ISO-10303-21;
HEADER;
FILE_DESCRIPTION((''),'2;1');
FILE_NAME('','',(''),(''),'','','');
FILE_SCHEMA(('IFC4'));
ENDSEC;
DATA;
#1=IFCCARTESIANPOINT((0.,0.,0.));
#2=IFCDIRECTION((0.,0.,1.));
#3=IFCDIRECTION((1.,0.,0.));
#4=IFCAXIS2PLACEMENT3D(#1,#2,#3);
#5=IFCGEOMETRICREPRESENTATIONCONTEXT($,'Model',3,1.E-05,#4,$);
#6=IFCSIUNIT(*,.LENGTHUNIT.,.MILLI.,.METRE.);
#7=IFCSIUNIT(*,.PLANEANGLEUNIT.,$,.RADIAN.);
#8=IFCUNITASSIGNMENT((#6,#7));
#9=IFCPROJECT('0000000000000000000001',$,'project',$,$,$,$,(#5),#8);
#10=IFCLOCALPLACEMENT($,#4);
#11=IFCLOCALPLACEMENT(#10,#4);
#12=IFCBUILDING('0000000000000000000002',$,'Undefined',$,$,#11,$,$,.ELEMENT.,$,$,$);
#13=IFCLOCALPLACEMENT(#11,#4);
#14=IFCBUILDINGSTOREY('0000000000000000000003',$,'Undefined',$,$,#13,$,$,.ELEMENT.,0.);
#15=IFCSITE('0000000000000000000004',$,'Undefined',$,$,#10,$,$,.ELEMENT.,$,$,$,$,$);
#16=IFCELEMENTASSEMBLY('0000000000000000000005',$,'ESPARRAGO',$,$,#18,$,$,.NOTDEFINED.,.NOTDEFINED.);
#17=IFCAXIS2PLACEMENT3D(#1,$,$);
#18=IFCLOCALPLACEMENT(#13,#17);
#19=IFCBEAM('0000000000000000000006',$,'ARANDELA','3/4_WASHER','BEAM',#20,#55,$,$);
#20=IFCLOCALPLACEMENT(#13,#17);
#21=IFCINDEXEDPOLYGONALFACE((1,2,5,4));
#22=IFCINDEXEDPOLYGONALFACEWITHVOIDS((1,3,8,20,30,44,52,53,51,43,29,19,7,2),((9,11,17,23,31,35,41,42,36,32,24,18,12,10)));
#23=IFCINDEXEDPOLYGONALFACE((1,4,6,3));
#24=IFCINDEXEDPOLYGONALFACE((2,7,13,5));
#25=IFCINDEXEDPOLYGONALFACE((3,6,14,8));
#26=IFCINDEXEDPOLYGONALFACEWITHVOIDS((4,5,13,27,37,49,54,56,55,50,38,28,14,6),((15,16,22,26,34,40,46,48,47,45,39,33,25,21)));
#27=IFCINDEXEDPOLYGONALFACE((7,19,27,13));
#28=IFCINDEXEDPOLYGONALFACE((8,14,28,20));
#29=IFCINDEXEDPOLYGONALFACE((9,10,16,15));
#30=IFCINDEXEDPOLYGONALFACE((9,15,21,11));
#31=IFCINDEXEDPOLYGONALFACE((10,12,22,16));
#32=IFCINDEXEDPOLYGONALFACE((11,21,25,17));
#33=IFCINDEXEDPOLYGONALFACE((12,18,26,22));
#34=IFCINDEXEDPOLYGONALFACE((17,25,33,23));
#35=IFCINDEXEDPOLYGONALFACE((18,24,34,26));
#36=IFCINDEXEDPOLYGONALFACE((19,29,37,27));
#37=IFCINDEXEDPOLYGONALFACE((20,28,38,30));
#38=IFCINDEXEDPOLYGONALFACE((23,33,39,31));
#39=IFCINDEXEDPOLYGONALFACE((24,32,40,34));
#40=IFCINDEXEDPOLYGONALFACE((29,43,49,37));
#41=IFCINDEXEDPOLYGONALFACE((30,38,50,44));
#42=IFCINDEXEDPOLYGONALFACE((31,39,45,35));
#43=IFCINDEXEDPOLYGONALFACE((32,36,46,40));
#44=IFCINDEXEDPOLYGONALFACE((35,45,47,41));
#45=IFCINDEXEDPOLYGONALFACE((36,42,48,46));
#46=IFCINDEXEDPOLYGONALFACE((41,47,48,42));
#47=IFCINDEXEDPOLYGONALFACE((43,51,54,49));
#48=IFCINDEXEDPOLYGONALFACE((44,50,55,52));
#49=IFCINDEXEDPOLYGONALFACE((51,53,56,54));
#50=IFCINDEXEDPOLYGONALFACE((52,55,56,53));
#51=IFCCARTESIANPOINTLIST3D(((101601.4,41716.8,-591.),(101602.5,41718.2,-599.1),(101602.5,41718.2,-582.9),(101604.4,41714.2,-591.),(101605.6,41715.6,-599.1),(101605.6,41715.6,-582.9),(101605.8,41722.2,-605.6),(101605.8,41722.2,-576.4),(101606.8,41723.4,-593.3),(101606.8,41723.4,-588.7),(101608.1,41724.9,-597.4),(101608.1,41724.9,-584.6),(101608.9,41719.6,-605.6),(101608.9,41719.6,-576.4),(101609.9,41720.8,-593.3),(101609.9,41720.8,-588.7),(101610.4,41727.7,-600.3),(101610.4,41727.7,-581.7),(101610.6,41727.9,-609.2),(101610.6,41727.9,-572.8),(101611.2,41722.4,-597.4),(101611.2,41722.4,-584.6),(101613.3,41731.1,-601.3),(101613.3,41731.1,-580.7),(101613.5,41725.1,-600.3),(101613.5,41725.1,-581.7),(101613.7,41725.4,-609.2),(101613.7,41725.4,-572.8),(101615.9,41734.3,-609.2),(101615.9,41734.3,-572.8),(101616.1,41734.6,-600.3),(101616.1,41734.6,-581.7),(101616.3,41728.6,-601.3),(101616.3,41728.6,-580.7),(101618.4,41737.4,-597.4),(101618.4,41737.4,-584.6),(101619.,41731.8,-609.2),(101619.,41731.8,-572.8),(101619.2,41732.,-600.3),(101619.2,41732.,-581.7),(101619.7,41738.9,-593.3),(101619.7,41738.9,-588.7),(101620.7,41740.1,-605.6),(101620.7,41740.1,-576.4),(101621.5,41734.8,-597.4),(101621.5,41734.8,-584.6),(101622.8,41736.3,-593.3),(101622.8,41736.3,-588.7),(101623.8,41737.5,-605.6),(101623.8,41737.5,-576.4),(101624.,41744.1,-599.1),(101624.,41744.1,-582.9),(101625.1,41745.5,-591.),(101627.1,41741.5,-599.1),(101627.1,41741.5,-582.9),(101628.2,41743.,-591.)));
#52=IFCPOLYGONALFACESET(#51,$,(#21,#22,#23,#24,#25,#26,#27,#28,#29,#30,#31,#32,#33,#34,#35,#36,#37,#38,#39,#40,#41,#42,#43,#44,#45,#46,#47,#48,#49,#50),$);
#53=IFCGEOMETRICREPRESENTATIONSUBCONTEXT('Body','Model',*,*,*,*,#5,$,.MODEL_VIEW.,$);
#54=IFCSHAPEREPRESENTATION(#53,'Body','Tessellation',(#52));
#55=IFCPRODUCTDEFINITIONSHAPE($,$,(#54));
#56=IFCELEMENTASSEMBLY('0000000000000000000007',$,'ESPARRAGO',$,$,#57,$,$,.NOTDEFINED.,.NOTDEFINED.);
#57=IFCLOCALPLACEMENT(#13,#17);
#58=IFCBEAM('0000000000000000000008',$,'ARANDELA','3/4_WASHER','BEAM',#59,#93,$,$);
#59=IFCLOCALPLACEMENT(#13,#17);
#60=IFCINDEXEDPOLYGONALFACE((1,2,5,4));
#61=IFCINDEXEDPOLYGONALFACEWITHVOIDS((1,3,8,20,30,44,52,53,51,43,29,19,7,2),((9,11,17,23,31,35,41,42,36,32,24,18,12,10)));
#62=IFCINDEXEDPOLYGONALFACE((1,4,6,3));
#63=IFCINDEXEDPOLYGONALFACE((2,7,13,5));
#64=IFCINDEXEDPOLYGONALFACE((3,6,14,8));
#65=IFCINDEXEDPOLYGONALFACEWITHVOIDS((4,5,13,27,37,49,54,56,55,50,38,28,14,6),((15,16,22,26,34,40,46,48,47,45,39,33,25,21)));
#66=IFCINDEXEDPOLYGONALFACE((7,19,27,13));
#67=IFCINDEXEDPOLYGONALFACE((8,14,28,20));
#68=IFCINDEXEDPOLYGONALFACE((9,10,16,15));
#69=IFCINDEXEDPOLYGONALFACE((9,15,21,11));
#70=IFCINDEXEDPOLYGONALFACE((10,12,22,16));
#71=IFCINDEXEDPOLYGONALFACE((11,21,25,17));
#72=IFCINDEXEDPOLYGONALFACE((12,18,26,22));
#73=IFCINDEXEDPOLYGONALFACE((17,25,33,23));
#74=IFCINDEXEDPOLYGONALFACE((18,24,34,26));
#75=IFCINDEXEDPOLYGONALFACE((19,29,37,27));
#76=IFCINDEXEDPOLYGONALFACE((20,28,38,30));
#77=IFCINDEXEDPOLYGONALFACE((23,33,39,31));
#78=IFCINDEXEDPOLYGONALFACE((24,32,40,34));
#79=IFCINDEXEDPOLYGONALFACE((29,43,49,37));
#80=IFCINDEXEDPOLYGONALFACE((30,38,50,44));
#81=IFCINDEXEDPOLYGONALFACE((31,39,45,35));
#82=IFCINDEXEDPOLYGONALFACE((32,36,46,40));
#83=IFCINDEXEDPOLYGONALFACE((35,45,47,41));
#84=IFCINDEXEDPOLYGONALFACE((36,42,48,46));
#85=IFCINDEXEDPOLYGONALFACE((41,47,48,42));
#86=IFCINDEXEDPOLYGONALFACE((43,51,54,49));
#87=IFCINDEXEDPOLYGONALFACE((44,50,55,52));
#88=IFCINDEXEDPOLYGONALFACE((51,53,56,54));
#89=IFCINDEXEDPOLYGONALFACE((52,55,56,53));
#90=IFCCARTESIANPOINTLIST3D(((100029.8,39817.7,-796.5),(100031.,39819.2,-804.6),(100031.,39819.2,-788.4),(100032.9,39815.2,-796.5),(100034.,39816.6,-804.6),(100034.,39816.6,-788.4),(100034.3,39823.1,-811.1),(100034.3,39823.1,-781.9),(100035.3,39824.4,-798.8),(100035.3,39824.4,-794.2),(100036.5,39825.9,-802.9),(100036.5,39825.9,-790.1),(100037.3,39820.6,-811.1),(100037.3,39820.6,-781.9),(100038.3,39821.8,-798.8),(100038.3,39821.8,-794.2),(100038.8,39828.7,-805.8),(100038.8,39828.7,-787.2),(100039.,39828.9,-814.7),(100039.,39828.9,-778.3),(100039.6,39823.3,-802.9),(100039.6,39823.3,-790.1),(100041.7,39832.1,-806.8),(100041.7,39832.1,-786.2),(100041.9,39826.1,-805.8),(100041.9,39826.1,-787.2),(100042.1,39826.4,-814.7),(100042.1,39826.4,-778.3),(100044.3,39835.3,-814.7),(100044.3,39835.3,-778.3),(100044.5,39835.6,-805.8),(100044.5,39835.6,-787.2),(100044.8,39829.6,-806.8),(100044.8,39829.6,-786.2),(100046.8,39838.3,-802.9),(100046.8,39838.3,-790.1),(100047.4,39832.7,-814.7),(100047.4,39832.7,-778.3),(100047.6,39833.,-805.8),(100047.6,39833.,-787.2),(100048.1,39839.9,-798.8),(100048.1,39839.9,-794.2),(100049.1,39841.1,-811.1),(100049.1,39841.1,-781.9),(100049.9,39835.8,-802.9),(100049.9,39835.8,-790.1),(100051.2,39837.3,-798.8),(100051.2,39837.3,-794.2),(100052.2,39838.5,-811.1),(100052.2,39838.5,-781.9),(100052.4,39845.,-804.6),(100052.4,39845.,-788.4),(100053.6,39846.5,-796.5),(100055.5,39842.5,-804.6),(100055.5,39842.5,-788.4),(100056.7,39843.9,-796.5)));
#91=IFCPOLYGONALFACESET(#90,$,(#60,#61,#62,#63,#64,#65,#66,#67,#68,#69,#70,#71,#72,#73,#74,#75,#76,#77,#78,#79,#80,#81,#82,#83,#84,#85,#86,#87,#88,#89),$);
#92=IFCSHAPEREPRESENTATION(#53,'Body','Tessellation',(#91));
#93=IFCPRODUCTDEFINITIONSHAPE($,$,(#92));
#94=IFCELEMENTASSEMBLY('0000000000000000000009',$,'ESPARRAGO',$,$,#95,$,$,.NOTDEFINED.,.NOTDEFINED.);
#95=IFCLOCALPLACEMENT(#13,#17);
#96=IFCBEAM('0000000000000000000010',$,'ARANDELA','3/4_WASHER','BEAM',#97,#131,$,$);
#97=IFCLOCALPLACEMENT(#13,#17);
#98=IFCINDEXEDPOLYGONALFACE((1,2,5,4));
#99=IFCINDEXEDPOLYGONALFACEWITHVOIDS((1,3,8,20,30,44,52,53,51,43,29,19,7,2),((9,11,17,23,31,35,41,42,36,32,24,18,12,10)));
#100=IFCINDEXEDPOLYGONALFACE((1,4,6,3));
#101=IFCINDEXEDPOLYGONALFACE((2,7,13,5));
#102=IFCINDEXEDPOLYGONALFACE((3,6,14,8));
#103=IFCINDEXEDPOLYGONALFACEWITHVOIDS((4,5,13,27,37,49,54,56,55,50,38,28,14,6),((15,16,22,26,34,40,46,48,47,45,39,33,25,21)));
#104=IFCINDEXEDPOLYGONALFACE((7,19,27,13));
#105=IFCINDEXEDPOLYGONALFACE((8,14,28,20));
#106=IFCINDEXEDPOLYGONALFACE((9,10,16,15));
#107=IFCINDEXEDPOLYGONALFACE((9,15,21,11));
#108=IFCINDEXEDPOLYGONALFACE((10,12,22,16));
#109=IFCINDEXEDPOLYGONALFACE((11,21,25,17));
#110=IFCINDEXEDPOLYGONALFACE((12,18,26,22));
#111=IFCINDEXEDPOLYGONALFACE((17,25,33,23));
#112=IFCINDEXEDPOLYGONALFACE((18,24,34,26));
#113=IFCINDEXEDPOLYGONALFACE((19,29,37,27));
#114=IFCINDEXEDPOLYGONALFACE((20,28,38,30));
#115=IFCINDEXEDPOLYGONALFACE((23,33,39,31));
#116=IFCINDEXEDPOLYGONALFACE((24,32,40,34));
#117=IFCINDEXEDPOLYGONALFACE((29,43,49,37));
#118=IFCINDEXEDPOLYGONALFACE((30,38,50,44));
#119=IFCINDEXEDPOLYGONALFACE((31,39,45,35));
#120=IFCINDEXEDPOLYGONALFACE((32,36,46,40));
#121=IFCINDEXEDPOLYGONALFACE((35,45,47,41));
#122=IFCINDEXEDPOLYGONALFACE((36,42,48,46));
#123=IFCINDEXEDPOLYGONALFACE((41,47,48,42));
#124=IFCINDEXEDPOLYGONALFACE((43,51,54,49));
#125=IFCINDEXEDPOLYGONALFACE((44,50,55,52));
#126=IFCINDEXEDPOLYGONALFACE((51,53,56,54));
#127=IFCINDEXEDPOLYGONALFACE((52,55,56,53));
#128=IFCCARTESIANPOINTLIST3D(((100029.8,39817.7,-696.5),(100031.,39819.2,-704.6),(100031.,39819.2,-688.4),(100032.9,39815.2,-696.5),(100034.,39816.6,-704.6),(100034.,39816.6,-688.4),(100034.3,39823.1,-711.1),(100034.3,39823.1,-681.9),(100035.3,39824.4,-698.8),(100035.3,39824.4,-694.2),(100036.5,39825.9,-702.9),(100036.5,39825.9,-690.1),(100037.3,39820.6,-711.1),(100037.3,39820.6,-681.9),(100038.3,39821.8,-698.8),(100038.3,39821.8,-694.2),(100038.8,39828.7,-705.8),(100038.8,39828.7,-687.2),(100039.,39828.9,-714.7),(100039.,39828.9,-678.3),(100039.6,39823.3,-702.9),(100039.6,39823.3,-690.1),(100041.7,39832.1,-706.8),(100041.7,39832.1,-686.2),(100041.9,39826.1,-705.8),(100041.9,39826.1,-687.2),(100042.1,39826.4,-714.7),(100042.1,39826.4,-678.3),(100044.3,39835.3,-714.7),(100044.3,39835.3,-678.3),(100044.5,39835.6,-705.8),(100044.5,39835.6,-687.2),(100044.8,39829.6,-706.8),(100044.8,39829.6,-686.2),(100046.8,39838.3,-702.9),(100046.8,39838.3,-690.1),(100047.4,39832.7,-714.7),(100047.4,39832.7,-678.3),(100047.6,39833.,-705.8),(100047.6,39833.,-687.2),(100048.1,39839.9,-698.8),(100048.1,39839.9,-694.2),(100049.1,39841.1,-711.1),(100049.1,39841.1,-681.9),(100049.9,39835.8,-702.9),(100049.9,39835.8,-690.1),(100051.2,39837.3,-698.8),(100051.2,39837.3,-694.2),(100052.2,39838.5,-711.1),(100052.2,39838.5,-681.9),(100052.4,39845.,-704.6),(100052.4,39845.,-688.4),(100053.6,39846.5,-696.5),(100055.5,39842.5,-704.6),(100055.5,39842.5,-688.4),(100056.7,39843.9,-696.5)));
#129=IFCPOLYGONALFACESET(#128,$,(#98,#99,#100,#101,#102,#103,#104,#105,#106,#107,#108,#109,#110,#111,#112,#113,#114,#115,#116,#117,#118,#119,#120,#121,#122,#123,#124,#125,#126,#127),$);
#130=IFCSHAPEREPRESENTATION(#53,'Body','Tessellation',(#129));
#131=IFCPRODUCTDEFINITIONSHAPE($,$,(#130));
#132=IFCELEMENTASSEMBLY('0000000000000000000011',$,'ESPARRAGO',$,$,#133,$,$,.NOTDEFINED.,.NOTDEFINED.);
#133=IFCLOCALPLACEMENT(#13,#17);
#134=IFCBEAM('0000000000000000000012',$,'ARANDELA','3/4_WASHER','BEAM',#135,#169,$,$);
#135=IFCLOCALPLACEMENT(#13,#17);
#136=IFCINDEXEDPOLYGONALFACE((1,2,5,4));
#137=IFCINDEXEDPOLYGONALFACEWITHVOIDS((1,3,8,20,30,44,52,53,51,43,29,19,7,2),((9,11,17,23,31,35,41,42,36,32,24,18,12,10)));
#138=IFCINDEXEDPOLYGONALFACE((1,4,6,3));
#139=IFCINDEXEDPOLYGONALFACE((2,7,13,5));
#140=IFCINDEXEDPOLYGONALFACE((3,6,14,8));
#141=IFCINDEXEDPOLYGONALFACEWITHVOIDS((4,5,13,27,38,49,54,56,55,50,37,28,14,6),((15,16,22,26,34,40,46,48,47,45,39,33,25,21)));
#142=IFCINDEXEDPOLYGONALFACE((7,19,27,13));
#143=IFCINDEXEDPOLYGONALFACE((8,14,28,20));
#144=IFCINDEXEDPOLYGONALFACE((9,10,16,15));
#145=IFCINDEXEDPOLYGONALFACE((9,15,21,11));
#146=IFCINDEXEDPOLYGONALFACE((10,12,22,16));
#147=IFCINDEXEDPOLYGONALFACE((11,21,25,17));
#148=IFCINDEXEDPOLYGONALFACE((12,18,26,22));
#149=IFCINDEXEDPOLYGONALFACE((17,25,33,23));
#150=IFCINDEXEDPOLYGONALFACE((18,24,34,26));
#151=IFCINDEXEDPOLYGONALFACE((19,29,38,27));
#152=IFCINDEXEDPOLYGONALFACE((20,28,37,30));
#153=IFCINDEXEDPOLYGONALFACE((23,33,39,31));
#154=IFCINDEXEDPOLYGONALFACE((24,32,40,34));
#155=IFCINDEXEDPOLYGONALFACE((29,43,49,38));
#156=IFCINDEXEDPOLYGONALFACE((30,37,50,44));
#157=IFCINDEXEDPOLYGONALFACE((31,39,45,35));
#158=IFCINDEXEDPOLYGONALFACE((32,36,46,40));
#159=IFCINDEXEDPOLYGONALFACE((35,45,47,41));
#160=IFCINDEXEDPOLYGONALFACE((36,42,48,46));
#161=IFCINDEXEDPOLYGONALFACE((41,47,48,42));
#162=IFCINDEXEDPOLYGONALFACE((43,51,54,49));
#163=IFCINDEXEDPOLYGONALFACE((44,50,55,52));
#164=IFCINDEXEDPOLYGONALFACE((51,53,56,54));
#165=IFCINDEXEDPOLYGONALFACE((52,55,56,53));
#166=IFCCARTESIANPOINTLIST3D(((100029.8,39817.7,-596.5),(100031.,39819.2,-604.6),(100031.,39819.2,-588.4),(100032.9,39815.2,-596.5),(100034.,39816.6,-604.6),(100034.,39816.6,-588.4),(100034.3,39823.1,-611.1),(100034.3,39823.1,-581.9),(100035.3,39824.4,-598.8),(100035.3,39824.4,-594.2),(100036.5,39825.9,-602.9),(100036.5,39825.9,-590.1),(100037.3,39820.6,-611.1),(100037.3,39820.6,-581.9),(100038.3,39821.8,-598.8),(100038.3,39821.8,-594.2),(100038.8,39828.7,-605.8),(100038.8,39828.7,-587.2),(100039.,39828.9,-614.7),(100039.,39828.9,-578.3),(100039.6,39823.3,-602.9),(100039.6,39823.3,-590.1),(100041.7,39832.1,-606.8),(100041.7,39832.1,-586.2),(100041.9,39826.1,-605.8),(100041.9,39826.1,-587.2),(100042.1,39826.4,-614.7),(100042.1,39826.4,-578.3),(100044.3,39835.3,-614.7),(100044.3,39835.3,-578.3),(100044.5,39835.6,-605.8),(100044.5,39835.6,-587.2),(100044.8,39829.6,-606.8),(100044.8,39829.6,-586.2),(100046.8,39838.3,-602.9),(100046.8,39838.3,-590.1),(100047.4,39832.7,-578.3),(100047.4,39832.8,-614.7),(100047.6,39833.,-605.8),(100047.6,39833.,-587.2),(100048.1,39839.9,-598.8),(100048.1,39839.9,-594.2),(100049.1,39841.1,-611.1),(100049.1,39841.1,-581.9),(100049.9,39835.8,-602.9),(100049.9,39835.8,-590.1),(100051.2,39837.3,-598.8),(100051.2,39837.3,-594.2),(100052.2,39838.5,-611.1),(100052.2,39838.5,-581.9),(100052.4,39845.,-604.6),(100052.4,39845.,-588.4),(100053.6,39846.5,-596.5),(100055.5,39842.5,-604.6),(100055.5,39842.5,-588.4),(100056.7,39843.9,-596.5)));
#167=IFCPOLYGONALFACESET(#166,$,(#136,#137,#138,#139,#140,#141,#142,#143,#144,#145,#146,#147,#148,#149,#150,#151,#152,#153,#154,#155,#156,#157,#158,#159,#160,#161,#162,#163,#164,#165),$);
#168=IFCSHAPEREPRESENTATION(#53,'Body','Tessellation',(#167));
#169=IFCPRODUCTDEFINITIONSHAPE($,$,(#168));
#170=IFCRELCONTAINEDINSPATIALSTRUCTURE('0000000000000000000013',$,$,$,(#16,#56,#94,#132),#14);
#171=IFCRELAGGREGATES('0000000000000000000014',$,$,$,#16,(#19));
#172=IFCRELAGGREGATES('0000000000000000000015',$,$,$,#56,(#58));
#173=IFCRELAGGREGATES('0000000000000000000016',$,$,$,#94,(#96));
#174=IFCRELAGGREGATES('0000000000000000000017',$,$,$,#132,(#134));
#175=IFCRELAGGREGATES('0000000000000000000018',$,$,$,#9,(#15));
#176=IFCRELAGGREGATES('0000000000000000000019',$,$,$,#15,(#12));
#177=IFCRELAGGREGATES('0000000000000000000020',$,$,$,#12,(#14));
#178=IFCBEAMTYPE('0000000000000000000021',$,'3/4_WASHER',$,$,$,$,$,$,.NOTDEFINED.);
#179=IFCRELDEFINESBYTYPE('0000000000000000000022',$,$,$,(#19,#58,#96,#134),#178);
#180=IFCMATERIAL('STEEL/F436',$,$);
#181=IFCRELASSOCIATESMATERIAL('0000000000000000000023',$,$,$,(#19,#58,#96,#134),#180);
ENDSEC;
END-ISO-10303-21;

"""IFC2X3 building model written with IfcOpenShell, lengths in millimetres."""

from ifc_helpers import new_model, si_unit, frame, origin_with_axes, place, context, subcontext, project, spatial, polyline, outline, extrude, material, type_object, element, aggregate, save


model = new_model("IFC2X3")

# Units and contexts
model_context = context("Model", 3, precision=1e-05, world=origin_with_axes())
body_context = subcontext(model_context, "Body", "Model", "MODEL_VIEW")
ifc_project = project(units=[si_unit("LENGTHUNIT", "METRE", prefix="MILLI"), si_unit("PLANEANGLEUNIT", "RADIAN")], contexts=[model_context])

# Site, building, storey
site_placement = place(None, origin_with_axes())
site = spatial("IfcSite", under=ifc_project, at=site_placement, Name="Undefined", CompositionType="ELEMENT")
building_placement = place(site_placement, origin_with_axes())
building = spatial("IfcBuilding", under=site, at=building_placement, Name="Undefined", CompositionType="ELEMENT")
storey_placement = place(building_placement, origin_with_axes())
storey = spatial("IfcBuildingStorey", under=building, at=storey_placement, Name="Undefined", CompositionType="ELEMENT", Elevation=0.0)

# Element assemblies, beams
ifc_material_1 = material(Name="STEEL/F436")
beam_type_1 = type_object("IfcBeamType", Name="3/4_WASHER", PredefinedType="NOTDEFINED")
assembly_1_placement = place(storey_placement, origin_with_axes())
assembly_1 = element("IfcElementAssembly", 1, at=assembly_1_placement, inside=storey, Name="ESPARRAGO", AssemblyPlace="NOTDEFINED", PredefinedType="NOTDEFINED")
beam_1_placement = place(assembly_1_placement, frame((101613.3, 41731.1, -591.0), z_axis=(0.000066, -0.000055, 1.0), x_axis=(0.7704, -0.637561, -0.000086)))
beam_1 = element("IfcBeam", 2, at=beam_1_placement, type_object=beam_type_1, material=ifc_material_1, Name="ARANDELA", Description="3/4_WASHER", ObjectType="BEAM", context=body_context, shape_type="SweptSolid", body=[
    extrude(outline(polyline([(-11.6, -14.6), (-16.8, -8.1), (-18.6, 0.0), (-16.8, 8.1), (-11.6, 14.6), (-4.2, 18.2), (4.2, 18.2), (11.6, 14.6), (16.8, 8.1), (18.6, 0.0), (16.8, -8.1), (11.6, -14.6), (4.2, -18.2), (-4.2, -18.2), (-11.6, -14.6)]), holes=[polyline([(-4.5, 9.3), (-8.1, 6.4), (-10.1, 2.3), (-10.1, -2.3), (-8.1, -6.4), (-4.5, -9.3), (0.0, -10.3), (4.5, -9.3), (8.1, -6.4), (10.1, -2.3), (10.1, 2.3), (8.1, 6.4), (4.5, 9.3), (0.0, 10.3), (-4.5, 9.3)])]), frame((4.0, 0.0, 0.0), z_axis=(-1.0, 0.0, 0.0), x_axis=(0.0, -1.0, 0.0)), (0.0, 0.0, 1.0), 4.0),
])
assembly_2_placement = place(storey_placement, origin_with_axes())
assembly_2 = element("IfcElementAssembly", 3, at=assembly_2_placement, inside=storey, Name="ESPARRAGO", AssemblyPlace="NOTDEFINED", PredefinedType="NOTDEFINED")
beam_2_placement = place(assembly_2_placement, frame((100041.7, 39832.1, -796.5), z_axis=(0.000066, -0.000055, 1.0), x_axis=(0.7704, -0.637561, -0.000086)))
beam_2 = element("IfcBeam", 4, at=beam_2_placement, type_object=beam_type_1, material=ifc_material_1, Name="ARANDELA", Description="3/4_WASHER", ObjectType="BEAM", context=body_context, shape_type="SweptSolid", body=[
    extrude(outline(polyline([(-11.6, -14.6), (-16.8, -8.1), (-18.6, 0.0), (-16.8, 8.1), (-11.6, 14.6), (-4.2, 18.2), (4.2, 18.2), (11.6, 14.6), (16.8, 8.1), (18.6, 0.0), (16.8, -8.1), (11.6, -14.6), (4.2, -18.2), (-4.2, -18.2), (-11.6, -14.6)]), holes=[polyline([(-4.5, 9.3), (-8.1, 6.4), (-10.1, 2.3), (-10.1, -2.3), (-8.1, -6.4), (-4.5, -9.3), (0.0, -10.3), (4.5, -9.3), (8.1, -6.4), (10.1, -2.3), (10.1, 2.3), (8.1, 6.4), (4.5, 9.3), (0.0, 10.3), (-4.5, 9.3)])]), frame((4.0, 0.0, 0.0), z_axis=(-1.0, 0.0, 0.0), x_axis=(0.0, -1.0, 0.0)), (0.0, 0.0, 1.0), 4.0),
])
assembly_3_placement = place(storey_placement, origin_with_axes())
assembly_3 = element("IfcElementAssembly", 5, at=assembly_3_placement, inside=storey, Name="ESPARRAGO", AssemblyPlace="NOTDEFINED", PredefinedType="NOTDEFINED")
beam_3_placement = place(assembly_3_placement, frame((100041.7, 39832.1, -696.5), z_axis=(0.000066, -0.000055, 1.0), x_axis=(0.7704, -0.637561, -0.000086)))
beam_3 = element("IfcBeam", 6, at=beam_3_placement, type_object=beam_type_1, material=ifc_material_1, Name="ARANDELA", Description="3/4_WASHER", ObjectType="BEAM", context=body_context, shape_type="SweptSolid", body=[
    extrude(outline(polyline([(-11.6, -14.6), (-16.8, -8.1), (-18.6, 0.0), (-16.8, 8.1), (-11.6, 14.6), (-4.2, 18.2), (4.2, 18.2), (11.6, 14.6), (16.8, 8.1), (18.6, 0.0), (16.8, -8.1), (11.6, -14.6), (4.2, -18.2), (-4.2, -18.2), (-11.6, -14.6)]), holes=[polyline([(-4.5, 9.3), (-8.1, 6.4), (-10.1, 2.3), (-10.1, -2.3), (-8.1, -6.4), (-4.5, -9.3), (0.0, -10.3), (4.5, -9.3), (8.1, -6.4), (10.1, -2.3), (10.1, 2.3), (8.1, 6.4), (4.5, 9.3), (0.0, 10.3), (-4.5, 9.3)])]), frame((4.0, 0.0, 0.0), z_axis=(-1.0, 0.0, 0.0), x_axis=(0.0, -1.0, 0.0)), (0.0, 0.0, 1.0), 4.0),
])
assembly_4_placement = place(storey_placement, origin_with_axes())
assembly_4 = element("IfcElementAssembly", 7, at=assembly_4_placement, inside=storey, Name="ESPARRAGO", AssemblyPlace="NOTDEFINED", PredefinedType="NOTDEFINED")
beam_4_placement = place(assembly_4_placement, frame((100041.7, 39832.1, -596.5), z_axis=(0.000066, -0.000055, 1.0), x_axis=(0.7704, -0.637561, -0.000086)))
beam_4 = element("IfcBeam", 8, at=beam_4_placement, type_object=beam_type_1, material=ifc_material_1, Name="ARANDELA", Description="3/4_WASHER", ObjectType="BEAM", context=body_context, shape_type="SweptSolid", body=[
    extrude(outline(polyline([(-11.6, -14.6), (-16.8, -8.1), (-18.6, 0.0), (-16.8, 8.1), (-11.6, 14.6), (-4.2, 18.2), (4.2, 18.2), (11.6, 14.6), (16.8, 8.1), (18.6, 0.0), (16.8, -8.1), (11.6, -14.6), (4.2, -18.2), (-4.2, -18.2), (-11.6, -14.6)]), holes=[polyline([(-4.5, 9.3), (-8.1, 6.4), (-10.1, 2.3), (-10.1, -2.3), (-8.1, -6.4), (-4.5, -9.3), (0.0, -10.3), (4.5, -9.3), (8.1, -6.4), (10.1, -2.3), (10.1, 2.3), (8.1, 6.4), (4.5, 9.3), (0.0, 10.3), (-4.5, 9.3)])]), frame((4.0, 0.0, 0.0), z_axis=(-1.0, 0.0, 0.0), x_axis=(0.0, -1.0, 0.0)), (0.0, 0.0, 1.0), 4.0),
])

aggregate(assembly_1, [beam_1])
aggregate(assembly_2, [beam_2])
aggregate(assembly_3, [beam_3])
aggregate(assembly_4, [beam_4])

save(model, "model.ifc")
